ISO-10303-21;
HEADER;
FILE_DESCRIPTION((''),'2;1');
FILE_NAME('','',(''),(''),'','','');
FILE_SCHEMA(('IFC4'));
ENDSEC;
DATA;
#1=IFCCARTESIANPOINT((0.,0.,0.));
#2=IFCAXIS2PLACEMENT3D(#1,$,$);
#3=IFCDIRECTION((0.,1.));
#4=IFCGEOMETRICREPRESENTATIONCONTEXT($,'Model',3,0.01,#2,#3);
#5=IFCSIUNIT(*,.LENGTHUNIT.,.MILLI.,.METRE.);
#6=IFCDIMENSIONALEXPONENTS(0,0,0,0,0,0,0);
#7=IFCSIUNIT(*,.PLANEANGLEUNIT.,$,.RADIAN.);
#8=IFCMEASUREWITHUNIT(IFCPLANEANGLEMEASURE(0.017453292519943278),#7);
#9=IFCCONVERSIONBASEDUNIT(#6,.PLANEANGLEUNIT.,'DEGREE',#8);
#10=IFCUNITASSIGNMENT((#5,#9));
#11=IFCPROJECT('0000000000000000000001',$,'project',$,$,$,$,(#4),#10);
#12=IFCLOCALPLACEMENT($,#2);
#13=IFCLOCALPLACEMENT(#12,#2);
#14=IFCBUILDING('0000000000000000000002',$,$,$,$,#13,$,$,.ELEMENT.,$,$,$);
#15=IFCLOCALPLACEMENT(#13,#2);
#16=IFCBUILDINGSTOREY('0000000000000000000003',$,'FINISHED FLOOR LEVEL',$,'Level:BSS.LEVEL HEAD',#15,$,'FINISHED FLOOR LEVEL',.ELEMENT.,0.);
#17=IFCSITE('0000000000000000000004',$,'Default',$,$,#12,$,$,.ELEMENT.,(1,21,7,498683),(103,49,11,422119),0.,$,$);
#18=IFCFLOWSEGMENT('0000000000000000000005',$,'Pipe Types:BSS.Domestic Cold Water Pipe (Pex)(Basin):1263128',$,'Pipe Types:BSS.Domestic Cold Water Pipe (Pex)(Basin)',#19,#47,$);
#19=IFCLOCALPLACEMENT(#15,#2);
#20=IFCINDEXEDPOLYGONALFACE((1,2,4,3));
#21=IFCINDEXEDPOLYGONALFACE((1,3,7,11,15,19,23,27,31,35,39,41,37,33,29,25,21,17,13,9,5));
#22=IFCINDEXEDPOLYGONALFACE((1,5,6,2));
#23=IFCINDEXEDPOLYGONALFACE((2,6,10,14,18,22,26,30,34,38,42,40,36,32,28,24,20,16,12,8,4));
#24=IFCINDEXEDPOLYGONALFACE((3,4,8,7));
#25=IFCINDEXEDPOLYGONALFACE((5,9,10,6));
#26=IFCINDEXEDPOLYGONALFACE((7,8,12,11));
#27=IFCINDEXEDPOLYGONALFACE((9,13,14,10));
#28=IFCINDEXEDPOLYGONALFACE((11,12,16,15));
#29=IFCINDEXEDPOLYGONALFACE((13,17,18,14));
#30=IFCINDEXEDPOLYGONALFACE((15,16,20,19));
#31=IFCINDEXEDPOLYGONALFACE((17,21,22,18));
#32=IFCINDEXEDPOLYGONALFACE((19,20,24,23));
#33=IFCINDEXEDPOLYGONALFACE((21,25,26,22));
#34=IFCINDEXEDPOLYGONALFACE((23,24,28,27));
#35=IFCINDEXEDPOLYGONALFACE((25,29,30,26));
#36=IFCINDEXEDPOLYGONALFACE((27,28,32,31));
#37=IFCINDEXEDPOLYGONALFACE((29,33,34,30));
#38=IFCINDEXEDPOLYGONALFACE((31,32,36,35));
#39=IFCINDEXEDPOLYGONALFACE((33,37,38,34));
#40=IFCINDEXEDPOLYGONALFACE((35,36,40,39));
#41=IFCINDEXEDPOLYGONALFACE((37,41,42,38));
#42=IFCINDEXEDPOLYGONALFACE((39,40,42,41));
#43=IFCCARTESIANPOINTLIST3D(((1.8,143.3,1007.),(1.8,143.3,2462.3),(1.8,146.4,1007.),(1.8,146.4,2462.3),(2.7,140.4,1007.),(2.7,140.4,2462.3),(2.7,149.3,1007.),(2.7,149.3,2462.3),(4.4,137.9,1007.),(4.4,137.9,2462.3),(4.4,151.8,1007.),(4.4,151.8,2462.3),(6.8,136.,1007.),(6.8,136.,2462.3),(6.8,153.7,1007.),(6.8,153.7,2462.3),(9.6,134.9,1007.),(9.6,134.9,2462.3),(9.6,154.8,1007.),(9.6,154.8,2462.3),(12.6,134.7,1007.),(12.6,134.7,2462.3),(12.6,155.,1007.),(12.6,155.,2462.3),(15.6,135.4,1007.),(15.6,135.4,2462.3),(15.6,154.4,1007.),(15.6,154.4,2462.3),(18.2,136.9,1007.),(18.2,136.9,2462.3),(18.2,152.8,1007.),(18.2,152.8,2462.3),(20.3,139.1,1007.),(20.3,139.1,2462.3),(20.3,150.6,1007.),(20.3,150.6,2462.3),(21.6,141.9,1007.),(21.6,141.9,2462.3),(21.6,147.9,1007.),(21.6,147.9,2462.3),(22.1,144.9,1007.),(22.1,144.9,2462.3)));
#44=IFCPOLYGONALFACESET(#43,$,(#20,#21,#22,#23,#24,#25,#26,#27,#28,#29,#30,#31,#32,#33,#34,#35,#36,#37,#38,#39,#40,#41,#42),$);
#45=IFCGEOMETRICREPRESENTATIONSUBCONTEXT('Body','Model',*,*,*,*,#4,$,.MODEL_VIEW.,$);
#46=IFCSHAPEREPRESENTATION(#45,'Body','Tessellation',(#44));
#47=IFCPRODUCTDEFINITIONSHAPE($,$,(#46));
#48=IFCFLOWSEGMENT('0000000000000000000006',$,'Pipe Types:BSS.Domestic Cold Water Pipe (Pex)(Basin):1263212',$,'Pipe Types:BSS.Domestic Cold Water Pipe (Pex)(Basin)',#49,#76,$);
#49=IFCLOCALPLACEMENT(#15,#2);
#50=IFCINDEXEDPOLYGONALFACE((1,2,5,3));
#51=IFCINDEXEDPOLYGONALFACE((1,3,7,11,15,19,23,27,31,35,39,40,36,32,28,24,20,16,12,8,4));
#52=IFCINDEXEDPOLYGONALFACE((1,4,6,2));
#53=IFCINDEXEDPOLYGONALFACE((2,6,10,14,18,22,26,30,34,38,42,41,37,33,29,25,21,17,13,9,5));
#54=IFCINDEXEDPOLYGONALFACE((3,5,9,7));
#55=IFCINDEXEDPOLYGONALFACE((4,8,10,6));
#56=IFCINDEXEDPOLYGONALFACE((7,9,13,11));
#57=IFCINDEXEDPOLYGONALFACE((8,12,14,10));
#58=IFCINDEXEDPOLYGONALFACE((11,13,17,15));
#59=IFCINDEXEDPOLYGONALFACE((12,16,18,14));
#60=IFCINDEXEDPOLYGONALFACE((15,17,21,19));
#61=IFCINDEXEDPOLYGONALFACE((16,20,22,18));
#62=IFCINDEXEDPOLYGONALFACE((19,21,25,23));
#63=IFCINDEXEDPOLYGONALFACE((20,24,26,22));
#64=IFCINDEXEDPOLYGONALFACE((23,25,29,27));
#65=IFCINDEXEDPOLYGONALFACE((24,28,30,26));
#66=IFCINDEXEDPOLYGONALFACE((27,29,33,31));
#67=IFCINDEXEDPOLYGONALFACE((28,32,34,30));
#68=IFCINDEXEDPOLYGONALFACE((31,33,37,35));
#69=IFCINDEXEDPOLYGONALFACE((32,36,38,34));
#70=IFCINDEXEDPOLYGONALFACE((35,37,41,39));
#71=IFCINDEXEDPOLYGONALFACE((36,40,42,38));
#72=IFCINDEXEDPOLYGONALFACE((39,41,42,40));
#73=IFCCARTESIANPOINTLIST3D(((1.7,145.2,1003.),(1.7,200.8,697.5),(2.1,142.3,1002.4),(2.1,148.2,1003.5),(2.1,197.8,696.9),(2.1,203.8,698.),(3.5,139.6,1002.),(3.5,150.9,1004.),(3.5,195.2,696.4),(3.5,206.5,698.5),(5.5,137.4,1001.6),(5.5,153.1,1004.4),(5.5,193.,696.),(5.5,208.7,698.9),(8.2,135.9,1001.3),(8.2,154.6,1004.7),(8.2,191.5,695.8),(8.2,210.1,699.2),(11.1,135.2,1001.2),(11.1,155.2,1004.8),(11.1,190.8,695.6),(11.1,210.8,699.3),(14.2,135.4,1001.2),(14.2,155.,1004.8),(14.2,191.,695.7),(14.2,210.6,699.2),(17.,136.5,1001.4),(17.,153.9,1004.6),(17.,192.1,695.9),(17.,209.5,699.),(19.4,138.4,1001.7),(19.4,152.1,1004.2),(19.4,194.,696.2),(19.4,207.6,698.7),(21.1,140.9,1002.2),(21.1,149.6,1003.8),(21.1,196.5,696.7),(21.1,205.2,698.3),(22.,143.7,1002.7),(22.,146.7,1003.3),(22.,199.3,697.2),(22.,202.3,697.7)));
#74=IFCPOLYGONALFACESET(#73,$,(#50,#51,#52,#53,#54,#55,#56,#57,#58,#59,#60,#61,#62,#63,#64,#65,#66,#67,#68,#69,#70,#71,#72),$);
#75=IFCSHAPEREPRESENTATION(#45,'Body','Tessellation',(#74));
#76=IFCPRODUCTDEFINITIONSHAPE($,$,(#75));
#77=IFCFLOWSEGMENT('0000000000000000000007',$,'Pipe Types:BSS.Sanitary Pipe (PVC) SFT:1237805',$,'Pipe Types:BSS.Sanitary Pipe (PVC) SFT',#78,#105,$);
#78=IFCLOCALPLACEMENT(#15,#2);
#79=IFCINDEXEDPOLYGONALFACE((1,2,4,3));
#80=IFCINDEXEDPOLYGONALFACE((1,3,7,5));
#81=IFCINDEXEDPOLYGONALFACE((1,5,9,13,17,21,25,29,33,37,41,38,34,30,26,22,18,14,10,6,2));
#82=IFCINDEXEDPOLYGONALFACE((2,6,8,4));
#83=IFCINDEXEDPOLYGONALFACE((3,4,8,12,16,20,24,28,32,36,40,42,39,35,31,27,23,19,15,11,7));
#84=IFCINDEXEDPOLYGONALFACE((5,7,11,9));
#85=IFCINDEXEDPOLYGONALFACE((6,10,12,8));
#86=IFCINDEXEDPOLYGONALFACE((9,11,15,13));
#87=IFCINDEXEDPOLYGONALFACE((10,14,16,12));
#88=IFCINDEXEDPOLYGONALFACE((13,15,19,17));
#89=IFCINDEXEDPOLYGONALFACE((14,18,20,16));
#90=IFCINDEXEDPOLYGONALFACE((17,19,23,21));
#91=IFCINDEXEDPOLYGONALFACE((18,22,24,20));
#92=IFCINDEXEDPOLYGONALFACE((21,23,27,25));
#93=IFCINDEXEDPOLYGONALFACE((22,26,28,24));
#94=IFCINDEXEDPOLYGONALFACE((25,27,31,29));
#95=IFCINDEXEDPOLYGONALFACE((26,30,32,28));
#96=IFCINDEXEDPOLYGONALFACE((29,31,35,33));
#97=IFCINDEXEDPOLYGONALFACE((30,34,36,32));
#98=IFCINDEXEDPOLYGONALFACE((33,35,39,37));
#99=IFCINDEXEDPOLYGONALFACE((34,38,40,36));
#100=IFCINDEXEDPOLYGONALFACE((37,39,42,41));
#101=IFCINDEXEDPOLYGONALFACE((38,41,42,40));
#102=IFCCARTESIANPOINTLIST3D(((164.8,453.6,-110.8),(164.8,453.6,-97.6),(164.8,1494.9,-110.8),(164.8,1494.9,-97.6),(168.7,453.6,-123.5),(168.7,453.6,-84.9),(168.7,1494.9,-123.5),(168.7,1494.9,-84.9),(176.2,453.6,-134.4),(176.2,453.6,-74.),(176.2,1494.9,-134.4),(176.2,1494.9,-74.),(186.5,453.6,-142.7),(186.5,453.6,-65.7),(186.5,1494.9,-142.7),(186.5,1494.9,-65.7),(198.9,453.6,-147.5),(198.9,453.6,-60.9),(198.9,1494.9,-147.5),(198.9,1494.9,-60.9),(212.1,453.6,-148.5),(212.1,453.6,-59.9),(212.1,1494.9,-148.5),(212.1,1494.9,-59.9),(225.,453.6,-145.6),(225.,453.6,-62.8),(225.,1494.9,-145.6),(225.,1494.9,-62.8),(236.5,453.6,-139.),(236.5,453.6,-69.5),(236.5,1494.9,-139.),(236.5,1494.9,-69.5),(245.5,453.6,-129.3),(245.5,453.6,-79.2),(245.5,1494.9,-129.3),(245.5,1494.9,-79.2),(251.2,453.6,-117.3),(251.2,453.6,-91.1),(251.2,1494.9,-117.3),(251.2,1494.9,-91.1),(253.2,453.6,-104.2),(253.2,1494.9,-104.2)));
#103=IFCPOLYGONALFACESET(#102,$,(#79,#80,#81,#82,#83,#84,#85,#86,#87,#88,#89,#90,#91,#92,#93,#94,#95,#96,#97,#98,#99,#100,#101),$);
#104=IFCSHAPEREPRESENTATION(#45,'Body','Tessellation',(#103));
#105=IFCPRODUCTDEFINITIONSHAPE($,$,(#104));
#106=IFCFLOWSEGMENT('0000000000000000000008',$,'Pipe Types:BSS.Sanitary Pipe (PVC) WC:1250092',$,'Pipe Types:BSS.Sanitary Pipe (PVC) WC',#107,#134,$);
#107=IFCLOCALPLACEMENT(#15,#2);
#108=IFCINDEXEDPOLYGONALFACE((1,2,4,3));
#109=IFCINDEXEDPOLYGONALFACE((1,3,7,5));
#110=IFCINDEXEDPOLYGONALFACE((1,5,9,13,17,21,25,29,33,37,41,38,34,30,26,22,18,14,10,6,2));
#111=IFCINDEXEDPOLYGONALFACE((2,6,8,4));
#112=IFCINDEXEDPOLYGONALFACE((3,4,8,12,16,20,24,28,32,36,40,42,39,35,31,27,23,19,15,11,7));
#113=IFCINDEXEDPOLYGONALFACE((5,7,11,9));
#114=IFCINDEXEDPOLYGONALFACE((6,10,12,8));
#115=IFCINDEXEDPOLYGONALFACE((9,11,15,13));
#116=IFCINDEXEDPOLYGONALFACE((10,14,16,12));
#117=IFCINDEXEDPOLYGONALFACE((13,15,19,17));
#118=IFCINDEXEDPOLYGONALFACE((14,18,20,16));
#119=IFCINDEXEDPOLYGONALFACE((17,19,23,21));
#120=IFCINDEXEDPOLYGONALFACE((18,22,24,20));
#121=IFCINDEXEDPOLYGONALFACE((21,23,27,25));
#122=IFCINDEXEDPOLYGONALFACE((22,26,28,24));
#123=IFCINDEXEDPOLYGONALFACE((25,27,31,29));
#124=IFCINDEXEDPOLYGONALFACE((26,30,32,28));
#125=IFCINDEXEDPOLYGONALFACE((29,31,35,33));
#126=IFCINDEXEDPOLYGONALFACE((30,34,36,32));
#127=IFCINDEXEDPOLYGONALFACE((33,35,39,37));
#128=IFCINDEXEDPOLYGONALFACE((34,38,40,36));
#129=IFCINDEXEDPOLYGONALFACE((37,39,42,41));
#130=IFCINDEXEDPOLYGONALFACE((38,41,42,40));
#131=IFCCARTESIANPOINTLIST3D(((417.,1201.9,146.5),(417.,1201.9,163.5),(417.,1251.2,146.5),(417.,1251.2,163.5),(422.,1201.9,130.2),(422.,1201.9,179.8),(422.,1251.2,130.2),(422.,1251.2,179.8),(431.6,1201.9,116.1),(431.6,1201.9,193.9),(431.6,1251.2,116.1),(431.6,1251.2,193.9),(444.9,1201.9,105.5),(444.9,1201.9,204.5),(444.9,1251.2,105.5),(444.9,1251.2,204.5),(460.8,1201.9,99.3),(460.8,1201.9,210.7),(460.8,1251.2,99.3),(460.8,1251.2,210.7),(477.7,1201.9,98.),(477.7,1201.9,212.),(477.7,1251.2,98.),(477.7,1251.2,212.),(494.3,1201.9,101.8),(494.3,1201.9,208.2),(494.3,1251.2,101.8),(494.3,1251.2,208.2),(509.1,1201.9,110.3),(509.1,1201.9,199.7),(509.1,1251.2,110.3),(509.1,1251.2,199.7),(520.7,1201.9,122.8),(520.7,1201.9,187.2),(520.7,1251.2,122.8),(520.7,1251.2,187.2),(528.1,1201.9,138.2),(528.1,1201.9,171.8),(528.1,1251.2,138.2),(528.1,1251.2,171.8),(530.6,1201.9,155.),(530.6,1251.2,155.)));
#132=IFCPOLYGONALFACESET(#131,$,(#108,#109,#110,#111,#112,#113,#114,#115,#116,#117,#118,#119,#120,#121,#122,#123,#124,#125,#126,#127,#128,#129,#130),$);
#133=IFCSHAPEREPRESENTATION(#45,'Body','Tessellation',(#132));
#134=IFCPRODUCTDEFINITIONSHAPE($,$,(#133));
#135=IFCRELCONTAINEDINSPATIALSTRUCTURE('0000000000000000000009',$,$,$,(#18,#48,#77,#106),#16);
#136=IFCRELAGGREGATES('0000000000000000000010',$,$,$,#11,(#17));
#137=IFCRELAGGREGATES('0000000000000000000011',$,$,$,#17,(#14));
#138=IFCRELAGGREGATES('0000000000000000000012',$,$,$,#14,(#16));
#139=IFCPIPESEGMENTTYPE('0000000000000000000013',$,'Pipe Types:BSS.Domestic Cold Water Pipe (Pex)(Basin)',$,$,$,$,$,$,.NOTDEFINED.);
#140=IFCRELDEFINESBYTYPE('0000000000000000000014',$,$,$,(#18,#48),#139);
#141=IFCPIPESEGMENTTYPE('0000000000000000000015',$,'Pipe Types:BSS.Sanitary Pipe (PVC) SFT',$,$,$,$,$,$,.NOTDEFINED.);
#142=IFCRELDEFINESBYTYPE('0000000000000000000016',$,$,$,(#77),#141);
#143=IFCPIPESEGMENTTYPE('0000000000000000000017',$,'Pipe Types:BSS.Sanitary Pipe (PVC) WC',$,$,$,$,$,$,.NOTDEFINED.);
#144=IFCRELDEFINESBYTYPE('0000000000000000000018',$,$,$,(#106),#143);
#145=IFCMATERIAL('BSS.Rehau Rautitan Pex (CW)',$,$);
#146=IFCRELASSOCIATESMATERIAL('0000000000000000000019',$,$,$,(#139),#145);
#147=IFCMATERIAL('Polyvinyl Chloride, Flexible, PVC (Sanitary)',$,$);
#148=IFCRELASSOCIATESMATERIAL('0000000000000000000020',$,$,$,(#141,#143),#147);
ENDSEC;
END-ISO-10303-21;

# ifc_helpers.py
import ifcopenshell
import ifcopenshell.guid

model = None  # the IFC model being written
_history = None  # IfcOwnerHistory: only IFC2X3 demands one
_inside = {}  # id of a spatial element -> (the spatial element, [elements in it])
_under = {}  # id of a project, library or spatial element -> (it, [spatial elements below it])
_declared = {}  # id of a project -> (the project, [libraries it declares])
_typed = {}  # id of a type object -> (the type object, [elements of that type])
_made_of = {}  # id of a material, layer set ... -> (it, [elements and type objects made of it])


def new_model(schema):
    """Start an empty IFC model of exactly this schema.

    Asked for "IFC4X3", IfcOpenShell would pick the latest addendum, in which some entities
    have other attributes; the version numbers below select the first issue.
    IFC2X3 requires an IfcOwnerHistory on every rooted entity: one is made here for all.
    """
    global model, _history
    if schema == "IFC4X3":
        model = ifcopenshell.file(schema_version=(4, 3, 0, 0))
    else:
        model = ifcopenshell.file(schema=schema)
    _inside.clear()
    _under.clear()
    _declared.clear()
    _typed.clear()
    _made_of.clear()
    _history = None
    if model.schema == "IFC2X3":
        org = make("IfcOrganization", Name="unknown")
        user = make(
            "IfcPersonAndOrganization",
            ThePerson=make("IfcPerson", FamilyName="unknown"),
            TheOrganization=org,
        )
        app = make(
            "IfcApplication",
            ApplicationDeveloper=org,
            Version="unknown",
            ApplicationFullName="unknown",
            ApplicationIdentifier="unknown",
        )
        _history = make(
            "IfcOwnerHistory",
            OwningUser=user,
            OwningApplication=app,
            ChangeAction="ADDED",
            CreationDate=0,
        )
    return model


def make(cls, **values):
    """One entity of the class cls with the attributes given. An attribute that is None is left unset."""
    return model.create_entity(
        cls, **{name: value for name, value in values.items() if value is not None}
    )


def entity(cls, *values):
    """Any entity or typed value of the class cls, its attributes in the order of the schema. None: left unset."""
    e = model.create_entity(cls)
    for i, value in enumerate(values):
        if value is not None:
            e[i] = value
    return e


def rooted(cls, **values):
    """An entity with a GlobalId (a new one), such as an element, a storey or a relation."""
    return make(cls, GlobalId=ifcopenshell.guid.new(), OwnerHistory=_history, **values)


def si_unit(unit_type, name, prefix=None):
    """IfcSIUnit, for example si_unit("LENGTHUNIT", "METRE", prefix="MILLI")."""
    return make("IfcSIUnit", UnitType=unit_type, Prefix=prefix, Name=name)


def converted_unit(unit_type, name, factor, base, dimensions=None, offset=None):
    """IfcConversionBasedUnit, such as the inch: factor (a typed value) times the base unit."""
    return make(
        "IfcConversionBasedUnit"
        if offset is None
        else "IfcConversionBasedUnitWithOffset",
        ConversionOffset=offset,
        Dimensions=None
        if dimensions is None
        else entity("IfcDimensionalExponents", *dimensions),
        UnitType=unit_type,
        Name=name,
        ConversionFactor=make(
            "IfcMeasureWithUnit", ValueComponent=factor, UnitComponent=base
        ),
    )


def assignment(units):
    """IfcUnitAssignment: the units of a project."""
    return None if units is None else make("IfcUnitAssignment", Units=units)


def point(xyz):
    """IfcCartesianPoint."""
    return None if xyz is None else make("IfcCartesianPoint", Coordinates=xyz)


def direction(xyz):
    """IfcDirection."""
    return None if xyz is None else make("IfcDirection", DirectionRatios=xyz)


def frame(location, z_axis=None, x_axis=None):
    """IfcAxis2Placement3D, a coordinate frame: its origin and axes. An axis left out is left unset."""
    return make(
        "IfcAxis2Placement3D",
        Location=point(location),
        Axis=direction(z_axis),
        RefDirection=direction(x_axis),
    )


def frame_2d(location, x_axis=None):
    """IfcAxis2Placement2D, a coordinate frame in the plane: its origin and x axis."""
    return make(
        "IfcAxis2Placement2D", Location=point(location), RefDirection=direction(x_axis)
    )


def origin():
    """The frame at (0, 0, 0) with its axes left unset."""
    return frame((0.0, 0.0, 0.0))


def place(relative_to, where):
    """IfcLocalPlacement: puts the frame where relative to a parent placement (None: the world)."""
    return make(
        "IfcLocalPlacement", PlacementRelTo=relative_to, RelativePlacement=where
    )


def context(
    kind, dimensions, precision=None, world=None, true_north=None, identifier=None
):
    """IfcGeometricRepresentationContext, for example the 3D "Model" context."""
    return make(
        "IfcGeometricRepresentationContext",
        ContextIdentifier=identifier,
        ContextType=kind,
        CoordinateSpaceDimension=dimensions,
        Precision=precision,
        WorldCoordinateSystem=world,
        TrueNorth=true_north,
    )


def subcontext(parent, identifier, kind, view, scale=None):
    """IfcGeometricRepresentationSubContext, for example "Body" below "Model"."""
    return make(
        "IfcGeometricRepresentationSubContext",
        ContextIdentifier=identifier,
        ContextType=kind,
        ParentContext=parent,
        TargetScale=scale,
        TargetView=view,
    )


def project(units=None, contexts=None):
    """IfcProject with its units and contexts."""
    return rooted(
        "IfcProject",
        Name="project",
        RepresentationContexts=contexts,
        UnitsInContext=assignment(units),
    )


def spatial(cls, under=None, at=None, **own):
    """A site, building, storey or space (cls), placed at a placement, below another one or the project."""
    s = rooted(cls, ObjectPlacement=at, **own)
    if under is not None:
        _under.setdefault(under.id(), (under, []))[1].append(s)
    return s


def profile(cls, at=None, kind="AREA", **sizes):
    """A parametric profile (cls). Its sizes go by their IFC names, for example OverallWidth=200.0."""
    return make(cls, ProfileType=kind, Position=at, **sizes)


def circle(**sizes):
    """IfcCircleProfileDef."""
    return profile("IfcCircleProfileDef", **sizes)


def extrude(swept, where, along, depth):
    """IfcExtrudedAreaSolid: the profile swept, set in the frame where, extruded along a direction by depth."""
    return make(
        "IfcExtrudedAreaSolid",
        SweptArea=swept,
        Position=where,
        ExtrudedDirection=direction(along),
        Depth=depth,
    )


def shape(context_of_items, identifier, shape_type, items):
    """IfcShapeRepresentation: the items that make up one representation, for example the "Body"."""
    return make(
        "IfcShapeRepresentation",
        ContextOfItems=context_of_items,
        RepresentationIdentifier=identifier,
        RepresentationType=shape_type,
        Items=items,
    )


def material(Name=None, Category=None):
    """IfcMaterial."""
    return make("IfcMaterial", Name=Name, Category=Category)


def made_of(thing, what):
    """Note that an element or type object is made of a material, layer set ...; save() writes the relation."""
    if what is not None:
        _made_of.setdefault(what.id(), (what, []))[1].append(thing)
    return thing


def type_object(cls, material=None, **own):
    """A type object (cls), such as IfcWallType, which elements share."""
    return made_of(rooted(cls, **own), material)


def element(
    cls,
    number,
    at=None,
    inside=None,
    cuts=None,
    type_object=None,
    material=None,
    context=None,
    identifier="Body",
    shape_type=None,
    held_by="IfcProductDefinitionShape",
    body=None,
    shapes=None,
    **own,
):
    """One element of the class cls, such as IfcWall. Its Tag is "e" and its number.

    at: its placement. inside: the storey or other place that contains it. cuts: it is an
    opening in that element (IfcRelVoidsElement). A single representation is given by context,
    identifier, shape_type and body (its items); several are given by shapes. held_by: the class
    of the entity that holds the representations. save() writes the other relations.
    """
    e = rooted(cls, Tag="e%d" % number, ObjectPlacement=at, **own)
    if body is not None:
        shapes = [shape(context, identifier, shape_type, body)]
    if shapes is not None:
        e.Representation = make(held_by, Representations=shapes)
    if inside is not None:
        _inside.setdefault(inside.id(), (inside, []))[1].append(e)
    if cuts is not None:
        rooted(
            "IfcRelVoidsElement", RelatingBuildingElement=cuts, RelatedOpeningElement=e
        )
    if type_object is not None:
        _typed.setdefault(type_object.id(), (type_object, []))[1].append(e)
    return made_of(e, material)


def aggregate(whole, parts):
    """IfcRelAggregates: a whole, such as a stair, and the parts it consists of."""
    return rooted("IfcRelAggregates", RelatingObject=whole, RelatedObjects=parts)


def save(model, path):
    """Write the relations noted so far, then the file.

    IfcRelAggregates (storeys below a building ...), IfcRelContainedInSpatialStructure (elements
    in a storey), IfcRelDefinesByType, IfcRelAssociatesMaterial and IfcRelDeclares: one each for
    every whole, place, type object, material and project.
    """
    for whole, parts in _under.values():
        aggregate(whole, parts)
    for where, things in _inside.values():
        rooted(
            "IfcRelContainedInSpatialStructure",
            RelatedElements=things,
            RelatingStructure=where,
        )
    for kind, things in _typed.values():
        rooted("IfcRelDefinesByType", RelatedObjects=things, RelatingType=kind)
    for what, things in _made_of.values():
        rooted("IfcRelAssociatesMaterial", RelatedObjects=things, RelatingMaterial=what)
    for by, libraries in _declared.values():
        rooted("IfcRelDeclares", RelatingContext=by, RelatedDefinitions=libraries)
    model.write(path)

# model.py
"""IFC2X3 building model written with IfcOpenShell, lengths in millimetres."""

from ifc_helpers import new_model, entity, si_unit, converted_unit, direction, frame, frame_2d, origin, place, context, subcontext, project, spatial, circle, extrude, material, type_object, element, save


model = new_model("IFC2X3")

# Units and contexts
model_context = context("Model", 3, precision=0.01, world=origin(), true_north=direction((0.0, 1.0)))
body_context = subcontext(model_context, "Body", "Model", "MODEL_VIEW")
ifc_project = project(units=[si_unit("LENGTHUNIT", "METRE", prefix="MILLI"), converted_unit("PLANEANGLEUNIT", "DEGREE", entity("IfcPlaneAngleMeasure", 0.017453292519943278), si_unit("PLANEANGLEUNIT", "RADIAN"), dimensions=[0, 0, 0, 0, 0, 0, 0])], contexts=[model_context])

# Site, building, storey
site_placement = place(None, origin())
site = spatial("IfcSite", under=ifc_project, at=site_placement, Name="Default", CompositionType="ELEMENT", RefLatitude=(1, 21, 7, 498683), RefLongitude=(103, 49, 11, 422119), RefElevation=0.0)
building_placement = place(site_placement, origin())
building = spatial("IfcBuilding", under=site, at=building_placement, CompositionType="ELEMENT")
storey_placement = place(building_placement, origin())
storey = spatial("IfcBuildingStorey", under=building, at=storey_placement, Name="FINISHED FLOOR LEVEL", ObjectType="Level:BSS.LEVEL HEAD", LongName="FINISHED FLOOR LEVEL", CompositionType="ELEMENT", Elevation=0.0)

# Flow segments
ifc_material_1 = material(Name="BSS.Rehau Rautitan Pex (CW)")
pipe_segment_type_1 = type_object("IfcPipeSegmentType", Name="Pipe Types:BSS.Domestic Cold Water Pipe (Pex)(Basin)", PredefinedType="NOTDEFINED", material=ifc_material_1)
flow_segment_1_placement = place(storey_placement, origin())
element("IfcFlowSegment", 1, at=flow_segment_1_placement, inside=storey, type_object=pipe_segment_type_1, Name="Pipe Types:BSS.Domestic Cold Water Pipe (Pex)(Basin):1263128", ObjectType="Pipe Types:BSS.Domestic Cold Water Pipe (Pex)(Basin)", context=body_context, shape_type="SweptSolid", body=[
    extrude(circle(Radius=10.2, at=frame_2d((0.0, 0.0), x_axis=(1.0, 0.0))), frame((11.9, 144.9, 1007.0)), (0.0, 0.0, 1.0), 1455.3),
])
flow_segment_2_placement = place(storey_placement, origin())
element("IfcFlowSegment", 2, at=flow_segment_2_placement, inside=storey, type_object=pipe_segment_type_1, Name="Pipe Types:BSS.Domestic Cold Water Pipe (Pex)(Basin):1263212", ObjectType="Pipe Types:BSS.Domestic Cold Water Pipe (Pex)(Basin)", context=body_context, shape_type="SweptSolid", body=[
    extrude(circle(Radius=10.2, at=frame_2d((0.0, 0.0), x_axis=(1.0, 0.0))), frame((11.9, 200.8, 697.5), z_axis=(0.0, -0.178966, 0.983855), x_axis=(-1.0, 0.0, 0.0)), (0.0, 0.0, 1.0), 310.5),
])
ifc_material_2 = material(Name="Polyvinyl Chloride, Flexible, PVC (Sanitary)")
pipe_segment_type_2 = type_object("IfcPipeSegmentType", Name="Pipe Types:BSS.Sanitary Pipe (PVC) SFT", PredefinedType="NOTDEFINED", material=ifc_material_2)
flow_segment_3_placement = place(storey_placement, origin())
element("IfcFlowSegment", 3, at=flow_segment_3_placement, inside=storey, type_object=pipe_segment_type_2, Name="Pipe Types:BSS.Sanitary Pipe (PVC) SFT:1237805", ObjectType="Pipe Types:BSS.Sanitary Pipe (PVC) SFT", context=body_context, shape_type="SweptSolid", body=[
    extrude(circle(Radius=44.5, at=frame_2d((0.0, 0.0), x_axis=(1.0, 0.0))), frame((208.8, 453.6, -104.2), z_axis=(0.0, 1.0, 0.0), x_axis=(1.0, 0.0, 0.0)), (0.0, 0.0, 1.0), 1041.2),
])
pipe_segment_type_3 = type_object("IfcPipeSegmentType", Name="Pipe Types:BSS.Sanitary Pipe (PVC) WC", PredefinedType="NOTDEFINED", material=ifc_material_2)
flow_segment_4_placement = place(storey_placement, origin())
element("IfcFlowSegment", 4, at=flow_segment_4_placement, inside=storey, type_object=pipe_segment_type_3, Name="Pipe Types:BSS.Sanitary Pipe (PVC) WC:1250092", ObjectType="Pipe Types:BSS.Sanitary Pipe (PVC) WC", context=body_context, shape_type="SweptSolid", body=[
    extrude(circle(Radius=57.2, at=frame_2d((0.0, 0.0), x_axis=(1.0, 0.0))), frame((473.5, 1201.9, 155.0), z_axis=(0.0, 1.0, 0.0), x_axis=(1.0, 0.0, 0.0)), (0.0, 0.0, 1.0), 49.2),
])

save(model, "model.ifc")
